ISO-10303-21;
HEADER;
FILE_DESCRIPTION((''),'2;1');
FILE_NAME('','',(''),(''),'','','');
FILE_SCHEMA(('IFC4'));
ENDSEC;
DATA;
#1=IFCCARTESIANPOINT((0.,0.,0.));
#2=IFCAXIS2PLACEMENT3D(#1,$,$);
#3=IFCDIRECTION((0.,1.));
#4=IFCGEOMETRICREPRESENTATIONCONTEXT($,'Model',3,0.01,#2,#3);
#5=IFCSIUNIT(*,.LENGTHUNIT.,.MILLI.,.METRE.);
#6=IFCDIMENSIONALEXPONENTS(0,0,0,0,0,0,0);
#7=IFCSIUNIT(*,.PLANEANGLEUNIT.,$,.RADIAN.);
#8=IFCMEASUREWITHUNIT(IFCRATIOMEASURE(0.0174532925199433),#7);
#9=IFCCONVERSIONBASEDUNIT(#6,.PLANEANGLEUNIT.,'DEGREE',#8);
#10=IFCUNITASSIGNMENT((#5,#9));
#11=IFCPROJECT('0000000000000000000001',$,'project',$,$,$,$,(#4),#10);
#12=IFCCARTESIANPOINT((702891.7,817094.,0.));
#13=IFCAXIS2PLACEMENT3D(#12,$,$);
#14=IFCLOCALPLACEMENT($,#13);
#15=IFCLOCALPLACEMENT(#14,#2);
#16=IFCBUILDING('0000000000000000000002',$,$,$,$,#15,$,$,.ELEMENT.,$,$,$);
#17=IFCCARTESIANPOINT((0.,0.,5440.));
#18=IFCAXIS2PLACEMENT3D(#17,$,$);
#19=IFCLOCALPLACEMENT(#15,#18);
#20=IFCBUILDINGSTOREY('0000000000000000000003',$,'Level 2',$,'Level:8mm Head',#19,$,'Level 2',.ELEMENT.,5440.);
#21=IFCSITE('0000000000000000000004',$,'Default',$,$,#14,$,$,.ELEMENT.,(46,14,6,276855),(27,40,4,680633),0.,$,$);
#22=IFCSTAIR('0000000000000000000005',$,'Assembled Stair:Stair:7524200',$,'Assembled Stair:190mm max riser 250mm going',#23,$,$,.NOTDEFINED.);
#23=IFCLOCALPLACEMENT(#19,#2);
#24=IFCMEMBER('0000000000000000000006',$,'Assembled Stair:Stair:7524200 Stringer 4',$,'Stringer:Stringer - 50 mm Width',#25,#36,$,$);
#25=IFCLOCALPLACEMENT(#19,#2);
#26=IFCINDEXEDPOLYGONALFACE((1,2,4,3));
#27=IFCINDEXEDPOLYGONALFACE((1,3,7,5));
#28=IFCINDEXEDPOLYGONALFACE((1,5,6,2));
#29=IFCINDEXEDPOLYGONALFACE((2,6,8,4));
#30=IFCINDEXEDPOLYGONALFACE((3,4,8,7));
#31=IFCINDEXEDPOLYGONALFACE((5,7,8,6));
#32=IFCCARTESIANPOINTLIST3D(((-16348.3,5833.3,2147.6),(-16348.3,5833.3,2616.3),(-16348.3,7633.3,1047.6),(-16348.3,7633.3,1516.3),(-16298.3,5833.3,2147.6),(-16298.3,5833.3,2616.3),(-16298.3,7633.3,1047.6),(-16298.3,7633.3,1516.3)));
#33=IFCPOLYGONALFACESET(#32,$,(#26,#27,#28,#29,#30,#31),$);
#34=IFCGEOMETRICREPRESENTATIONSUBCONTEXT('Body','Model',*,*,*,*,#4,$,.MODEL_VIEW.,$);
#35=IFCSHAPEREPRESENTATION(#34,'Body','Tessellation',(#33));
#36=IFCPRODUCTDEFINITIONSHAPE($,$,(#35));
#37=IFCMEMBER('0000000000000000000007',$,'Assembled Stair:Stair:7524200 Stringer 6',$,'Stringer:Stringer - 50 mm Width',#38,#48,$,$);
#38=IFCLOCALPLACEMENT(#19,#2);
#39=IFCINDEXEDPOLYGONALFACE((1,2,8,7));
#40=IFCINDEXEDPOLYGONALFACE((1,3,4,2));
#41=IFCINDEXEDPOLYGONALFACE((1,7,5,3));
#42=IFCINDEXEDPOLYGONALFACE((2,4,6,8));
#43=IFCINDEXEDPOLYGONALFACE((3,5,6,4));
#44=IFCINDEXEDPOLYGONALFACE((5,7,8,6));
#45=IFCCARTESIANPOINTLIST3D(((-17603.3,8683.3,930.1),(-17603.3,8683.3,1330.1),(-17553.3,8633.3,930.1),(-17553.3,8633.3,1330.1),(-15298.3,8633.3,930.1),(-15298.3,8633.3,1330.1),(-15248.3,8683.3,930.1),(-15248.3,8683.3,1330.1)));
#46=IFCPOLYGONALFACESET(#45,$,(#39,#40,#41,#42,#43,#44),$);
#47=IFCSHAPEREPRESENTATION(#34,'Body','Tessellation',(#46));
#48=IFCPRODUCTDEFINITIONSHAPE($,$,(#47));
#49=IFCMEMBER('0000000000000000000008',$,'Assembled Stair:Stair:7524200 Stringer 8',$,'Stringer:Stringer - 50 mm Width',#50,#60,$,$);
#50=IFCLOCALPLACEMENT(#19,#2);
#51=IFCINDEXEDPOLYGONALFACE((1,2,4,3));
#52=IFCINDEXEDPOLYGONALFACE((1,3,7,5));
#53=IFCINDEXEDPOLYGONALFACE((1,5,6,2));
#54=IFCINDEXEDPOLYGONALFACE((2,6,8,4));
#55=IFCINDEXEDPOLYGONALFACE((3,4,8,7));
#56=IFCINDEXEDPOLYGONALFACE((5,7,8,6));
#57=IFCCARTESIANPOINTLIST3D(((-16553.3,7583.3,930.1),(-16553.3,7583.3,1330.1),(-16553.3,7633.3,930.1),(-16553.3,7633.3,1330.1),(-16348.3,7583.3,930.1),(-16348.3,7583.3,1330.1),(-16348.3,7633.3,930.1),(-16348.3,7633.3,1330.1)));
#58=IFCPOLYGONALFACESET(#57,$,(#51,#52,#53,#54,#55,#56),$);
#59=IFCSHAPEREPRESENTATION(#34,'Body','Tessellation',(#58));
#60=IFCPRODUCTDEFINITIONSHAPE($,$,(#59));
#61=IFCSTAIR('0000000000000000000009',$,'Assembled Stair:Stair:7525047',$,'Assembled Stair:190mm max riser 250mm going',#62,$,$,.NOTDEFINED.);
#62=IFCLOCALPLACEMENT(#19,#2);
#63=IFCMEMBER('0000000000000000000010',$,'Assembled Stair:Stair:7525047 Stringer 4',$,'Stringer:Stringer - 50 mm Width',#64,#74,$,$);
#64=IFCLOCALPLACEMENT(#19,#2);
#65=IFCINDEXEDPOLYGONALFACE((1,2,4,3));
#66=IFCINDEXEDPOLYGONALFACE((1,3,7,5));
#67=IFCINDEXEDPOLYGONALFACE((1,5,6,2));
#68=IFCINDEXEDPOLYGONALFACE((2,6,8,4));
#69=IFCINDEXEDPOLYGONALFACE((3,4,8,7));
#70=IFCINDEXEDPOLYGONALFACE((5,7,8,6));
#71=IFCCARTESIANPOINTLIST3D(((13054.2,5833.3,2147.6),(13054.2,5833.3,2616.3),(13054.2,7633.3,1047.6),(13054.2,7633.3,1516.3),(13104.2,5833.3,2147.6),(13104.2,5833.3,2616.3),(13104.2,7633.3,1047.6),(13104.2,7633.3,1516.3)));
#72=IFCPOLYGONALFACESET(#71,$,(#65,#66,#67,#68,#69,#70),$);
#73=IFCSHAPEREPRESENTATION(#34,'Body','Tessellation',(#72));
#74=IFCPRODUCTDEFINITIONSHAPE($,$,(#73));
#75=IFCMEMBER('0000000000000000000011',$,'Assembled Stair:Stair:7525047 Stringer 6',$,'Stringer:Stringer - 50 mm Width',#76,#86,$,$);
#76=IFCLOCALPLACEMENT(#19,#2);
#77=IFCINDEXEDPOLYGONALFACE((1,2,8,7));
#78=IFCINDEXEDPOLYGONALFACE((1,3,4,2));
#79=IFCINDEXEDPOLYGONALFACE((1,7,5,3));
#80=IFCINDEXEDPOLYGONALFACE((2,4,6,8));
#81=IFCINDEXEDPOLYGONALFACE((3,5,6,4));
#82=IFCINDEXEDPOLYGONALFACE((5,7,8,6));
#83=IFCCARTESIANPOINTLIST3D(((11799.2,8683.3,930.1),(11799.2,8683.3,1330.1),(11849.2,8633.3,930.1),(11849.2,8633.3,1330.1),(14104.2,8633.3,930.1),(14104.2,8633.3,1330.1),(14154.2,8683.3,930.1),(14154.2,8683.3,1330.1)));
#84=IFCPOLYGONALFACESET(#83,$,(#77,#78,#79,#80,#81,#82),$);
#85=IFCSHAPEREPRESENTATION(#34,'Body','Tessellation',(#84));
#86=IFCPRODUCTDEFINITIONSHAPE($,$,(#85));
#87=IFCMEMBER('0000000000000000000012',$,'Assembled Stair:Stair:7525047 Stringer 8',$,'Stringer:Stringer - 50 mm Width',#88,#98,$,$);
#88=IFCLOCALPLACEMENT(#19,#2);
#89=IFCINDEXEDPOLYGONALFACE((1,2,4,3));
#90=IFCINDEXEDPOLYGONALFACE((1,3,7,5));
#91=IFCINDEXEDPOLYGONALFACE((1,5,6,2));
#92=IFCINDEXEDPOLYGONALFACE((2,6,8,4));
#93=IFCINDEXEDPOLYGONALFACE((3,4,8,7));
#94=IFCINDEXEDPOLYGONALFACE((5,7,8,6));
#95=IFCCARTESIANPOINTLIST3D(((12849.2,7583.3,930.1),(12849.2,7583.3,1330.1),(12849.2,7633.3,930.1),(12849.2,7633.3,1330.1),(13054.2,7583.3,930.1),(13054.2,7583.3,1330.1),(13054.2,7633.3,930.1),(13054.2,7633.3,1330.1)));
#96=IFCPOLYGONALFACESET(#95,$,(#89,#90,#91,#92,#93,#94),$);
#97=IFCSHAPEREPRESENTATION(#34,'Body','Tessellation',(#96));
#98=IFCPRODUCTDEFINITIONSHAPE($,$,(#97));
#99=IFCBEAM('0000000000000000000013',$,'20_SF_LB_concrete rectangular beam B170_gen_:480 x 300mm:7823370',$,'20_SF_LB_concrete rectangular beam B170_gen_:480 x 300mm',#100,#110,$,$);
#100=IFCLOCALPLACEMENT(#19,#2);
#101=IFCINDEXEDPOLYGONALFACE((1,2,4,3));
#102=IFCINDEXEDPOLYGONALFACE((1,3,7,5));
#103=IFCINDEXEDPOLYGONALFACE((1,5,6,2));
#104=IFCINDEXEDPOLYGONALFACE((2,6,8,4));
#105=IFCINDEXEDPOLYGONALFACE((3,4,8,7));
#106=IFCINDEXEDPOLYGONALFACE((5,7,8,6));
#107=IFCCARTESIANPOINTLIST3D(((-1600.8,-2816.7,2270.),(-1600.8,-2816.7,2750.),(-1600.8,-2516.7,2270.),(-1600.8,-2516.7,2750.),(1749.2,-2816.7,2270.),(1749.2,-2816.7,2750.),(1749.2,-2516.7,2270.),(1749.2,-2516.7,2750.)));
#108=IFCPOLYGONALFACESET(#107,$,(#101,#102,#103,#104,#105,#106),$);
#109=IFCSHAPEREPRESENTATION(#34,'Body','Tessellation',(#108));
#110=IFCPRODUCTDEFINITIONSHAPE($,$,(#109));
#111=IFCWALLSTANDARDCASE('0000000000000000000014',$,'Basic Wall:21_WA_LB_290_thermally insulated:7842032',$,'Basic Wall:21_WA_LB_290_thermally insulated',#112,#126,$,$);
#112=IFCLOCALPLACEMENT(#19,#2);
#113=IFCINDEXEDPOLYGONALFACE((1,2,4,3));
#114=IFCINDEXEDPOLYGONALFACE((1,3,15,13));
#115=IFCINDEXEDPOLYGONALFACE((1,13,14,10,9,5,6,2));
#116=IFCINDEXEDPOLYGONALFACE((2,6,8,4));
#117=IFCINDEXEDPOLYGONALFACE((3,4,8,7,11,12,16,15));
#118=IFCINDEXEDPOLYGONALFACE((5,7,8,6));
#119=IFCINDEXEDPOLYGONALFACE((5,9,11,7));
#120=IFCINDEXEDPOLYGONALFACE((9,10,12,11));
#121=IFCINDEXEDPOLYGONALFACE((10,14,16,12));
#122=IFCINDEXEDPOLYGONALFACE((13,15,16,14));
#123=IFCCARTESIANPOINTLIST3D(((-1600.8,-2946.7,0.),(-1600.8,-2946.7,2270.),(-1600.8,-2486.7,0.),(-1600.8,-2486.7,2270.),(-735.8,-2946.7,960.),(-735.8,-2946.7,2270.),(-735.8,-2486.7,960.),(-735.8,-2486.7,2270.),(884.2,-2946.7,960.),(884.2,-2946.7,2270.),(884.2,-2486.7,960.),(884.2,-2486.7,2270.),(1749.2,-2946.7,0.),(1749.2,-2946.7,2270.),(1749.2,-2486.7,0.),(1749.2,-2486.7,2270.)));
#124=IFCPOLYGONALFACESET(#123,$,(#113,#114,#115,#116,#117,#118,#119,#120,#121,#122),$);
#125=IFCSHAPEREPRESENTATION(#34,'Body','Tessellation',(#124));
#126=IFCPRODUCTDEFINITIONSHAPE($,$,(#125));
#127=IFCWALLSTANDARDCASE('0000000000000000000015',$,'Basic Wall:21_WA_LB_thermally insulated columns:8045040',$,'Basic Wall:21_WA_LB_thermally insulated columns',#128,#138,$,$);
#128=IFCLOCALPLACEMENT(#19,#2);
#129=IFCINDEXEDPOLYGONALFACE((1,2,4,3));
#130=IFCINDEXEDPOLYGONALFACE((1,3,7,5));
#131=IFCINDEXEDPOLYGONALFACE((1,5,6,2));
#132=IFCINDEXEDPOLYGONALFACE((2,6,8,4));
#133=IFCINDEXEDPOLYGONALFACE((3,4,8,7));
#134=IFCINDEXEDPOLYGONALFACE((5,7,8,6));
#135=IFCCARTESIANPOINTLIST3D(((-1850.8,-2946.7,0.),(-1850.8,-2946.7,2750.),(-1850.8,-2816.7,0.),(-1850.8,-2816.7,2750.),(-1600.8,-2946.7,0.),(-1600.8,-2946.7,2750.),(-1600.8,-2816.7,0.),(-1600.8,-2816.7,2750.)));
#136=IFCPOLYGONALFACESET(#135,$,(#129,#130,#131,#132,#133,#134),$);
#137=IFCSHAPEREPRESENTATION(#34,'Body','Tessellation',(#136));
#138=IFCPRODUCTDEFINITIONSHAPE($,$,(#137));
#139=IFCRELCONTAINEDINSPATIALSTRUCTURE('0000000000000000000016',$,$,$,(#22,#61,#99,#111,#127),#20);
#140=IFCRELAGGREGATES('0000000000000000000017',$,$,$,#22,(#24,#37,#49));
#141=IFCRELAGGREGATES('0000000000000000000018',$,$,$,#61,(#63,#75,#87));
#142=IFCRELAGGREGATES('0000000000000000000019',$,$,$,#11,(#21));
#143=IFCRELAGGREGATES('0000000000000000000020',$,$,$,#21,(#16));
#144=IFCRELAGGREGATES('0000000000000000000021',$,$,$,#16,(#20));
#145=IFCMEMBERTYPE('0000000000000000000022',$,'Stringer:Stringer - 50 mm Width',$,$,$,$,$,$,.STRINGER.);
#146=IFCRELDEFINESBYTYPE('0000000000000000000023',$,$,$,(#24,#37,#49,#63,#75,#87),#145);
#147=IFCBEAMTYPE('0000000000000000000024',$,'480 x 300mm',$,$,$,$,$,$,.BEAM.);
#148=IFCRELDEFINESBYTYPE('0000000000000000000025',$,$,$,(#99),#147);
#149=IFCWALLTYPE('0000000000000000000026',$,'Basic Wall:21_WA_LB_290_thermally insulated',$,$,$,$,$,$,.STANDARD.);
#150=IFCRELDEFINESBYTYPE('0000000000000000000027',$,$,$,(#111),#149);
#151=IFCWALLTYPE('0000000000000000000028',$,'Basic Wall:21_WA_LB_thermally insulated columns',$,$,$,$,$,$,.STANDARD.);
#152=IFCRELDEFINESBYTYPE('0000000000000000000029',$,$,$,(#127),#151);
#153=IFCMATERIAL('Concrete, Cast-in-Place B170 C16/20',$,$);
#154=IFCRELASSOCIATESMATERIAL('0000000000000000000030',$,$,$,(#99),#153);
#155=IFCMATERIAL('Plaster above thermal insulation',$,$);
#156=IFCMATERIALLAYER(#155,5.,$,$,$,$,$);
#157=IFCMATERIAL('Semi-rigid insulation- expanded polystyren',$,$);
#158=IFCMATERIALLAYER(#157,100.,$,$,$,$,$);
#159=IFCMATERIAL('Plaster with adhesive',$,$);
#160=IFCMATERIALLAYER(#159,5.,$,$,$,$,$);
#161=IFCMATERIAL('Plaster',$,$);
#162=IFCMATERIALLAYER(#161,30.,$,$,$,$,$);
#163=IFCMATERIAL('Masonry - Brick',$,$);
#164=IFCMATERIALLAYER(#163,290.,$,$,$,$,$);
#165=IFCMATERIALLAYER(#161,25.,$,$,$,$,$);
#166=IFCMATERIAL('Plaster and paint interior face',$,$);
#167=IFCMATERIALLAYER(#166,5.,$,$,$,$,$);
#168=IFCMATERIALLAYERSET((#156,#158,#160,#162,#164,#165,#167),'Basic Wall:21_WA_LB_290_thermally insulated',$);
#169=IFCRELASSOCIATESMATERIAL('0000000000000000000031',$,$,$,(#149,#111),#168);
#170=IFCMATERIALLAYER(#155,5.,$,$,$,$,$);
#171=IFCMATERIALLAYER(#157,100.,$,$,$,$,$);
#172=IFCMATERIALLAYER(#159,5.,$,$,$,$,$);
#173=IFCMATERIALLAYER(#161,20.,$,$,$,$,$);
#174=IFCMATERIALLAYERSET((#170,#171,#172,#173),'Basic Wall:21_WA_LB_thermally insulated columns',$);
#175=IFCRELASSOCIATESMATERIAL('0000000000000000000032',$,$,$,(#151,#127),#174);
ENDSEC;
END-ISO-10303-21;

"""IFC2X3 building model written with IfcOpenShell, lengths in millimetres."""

from ifc_helpers import new_model, entity, si_unit, converted_unit, direction, frame, frame_2d, origin, origin_2d_with_axis, place, context, subcontext, project, spatial, polyline, rectangle, outline, extrude, clip, halfspace, material, layer, layer_set, layer_usage, type_object, element, aggregate, save


model = new_model("IFC2X3")

# Units and contexts
model_context = context("Model", 3, precision=0.01, world=origin(), true_north=direction((0.0, 1.0)))
body_context = subcontext(model_context, "Body", "Model", "MODEL_VIEW")
ifc_project = project(units=[si_unit("LENGTHUNIT", "METRE", prefix="MILLI"), converted_unit("PLANEANGLEUNIT", "DEGREE", entity("IfcRatioMeasure", 0.0174532925199433), si_unit("PLANEANGLEUNIT", "RADIAN"), dimensions=[0, 0, 0, 0, 0, 0, 0])], contexts=[model_context])

# Site, building, storey
site_placement = place(None, frame((702891.7, 817094.0, 0.0)))
site = spatial("IfcSite", under=ifc_project, at=site_placement, Name="Default", CompositionType="ELEMENT", RefLatitude=(46, 14, 6, 276855), RefLongitude=(27, 40, 4, 680633), RefElevation=0.0)
building_placement = place(site_placement, origin())
building = spatial("IfcBuilding", under=site, at=building_placement, CompositionType="ELEMENT")
storey_placement = place(building_placement, frame((0.0, 0.0, 5440.0)))
storey = spatial("IfcBuildingStorey", under=building, at=storey_placement, Name="Level 2", ObjectType="Level:8mm Head", LongName="Level 2", CompositionType="ELEMENT", Elevation=5440.0)

# Stairs, members
stair_1_placement = place(storey_placement, origin())
stair_1 = element("IfcStair", 1, at=stair_1_placement, inside=storey, Name="Assembled Stair:Stair:7524200", ObjectType="Assembled Stair:190mm max riser 250mm going", ShapeType="NOTDEFINED")
member_type = type_object("IfcMemberType", Name="Stringer:Stringer - 50 mm Width", PredefinedType="STRINGER")
member_1_placement = place(stair_1_placement, origin())
member_1 = element("IfcMember", 2, at=member_1_placement, type_object=member_type, Name="Assembled Stair:Stair:7524200 Stringer 4", ObjectType="Stringer:Stringer - 50 mm Width", context=body_context, shape_type="SweptSolid", body=[
    extrude(outline(polyline([(-932.5, -200.0), (1177.0, -200.0), (932.5, 200.0), (-1177.0, 200.0), (-932.5, -200.0)])), frame((-16348.3, 6733.3, 1831.9), z_axis=(1.0, 0.0, 0.0), x_axis=(0.0, -0.853282, 0.52145)), (0.0, 0.0, 1.0), 50.0),
])
member_2_placement = place(stair_1_placement, origin())
member_2 = element("IfcMember", 3, at=member_2_placement, type_object=member_type, Name="Assembled Stair:Stair:7524200 Stringer 6", ObjectType="Stringer:Stringer - 50 mm Width", context=body_context, shape_type="SweptSolid", body=[
    extrude(outline(polyline([(-1177.5, -25.0), (1177.5, -25.0), (1127.5, 25.0), (-1127.5, 25.0), (-1177.5, -25.0)])), frame((-16425.8, 8658.3, 930.1), z_axis=(0.0, 0.0, 1.0), x_axis=(-1.0, 0.0, 0.0)), (0.0, 0.0, 1.0), 400.0),
])
member_3_placement = place(stair_1_placement, origin())
member_3 = element("IfcMember", 4, at=member_3_placement, type_object=member_type, Name="Assembled Stair:Stair:7524200 Stringer 8", ObjectType="Stringer:Stringer - 50 mm Width", context=body_context, shape_type="SweptSolid", body=[
    extrude(rectangle(XDim=205.0, YDim=50.0, at=origin_2d_with_axis()), frame((-16450.8, 7608.3, 930.1)), (0.0, 0.0, 1.0), 400.0),
])
stair_2_placement = place(storey_placement, origin())
stair_2 = element("IfcStair", 5, at=stair_2_placement, inside=storey, Name="Assembled Stair:Stair:7525047", ObjectType="Assembled Stair:190mm max riser 250mm going", ShapeType="NOTDEFINED")
member_4_placement = place(stair_2_placement, origin())
member_4 = element("IfcMember", 6, at=member_4_placement, type_object=member_type, Name="Assembled Stair:Stair:7525047 Stringer 4", ObjectType="Stringer:Stringer - 50 mm Width", context=body_context, shape_type="SweptSolid", body=[
    extrude(outline(polyline([(-932.5, -200.0), (1177.0, -200.0), (932.5, 200.0), (-1177.0, 200.0), (-932.5, -200.0)])), frame((13054.2, 6733.3, 1831.9), z_axis=(1.0, 0.0, 0.0), x_axis=(0.0, -0.853282, 0.52145)), (0.0, 0.0, 1.0), 50.0),
])
member_5_placement = place(stair_2_placement, origin())
member_5 = element("IfcMember", 7, at=member_5_placement, type_object=member_type, Name="Assembled Stair:Stair:7525047 Stringer 6", ObjectType="Stringer:Stringer - 50 mm Width", context=body_context, shape_type="SweptSolid", body=[
    extrude(outline(polyline([(-1177.5, -25.0), (1177.5, -25.0), (1127.5, 25.0), (-1127.5, 25.0), (-1177.5, -25.0)])), frame((12976.7, 8658.3, 930.1), z_axis=(0.0, 0.0, 1.0), x_axis=(-1.0, 0.0, 0.0)), (0.0, 0.0, 1.0), 400.0),
])
member_6_placement = place(stair_2_placement, origin())
member_6 = element("IfcMember", 8, at=member_6_placement, type_object=member_type, Name="Assembled Stair:Stair:7525047 Stringer 8", ObjectType="Stringer:Stringer - 50 mm Width", context=body_context, shape_type="SweptSolid", body=[
    extrude(rectangle(XDim=205.0, YDim=50.0, at=frame_2d((0.0, 0.0), x_axis=(1.0, 0.0))), frame((12951.7, 7608.3, 930.1)), (0.0, 0.0, 1.0), 400.0),
])

# Beam
ifc_material_1 = material(Name="Concrete, Cast-in-Place B170 C16/20")
beam_type = type_object("IfcBeamType", Name="480 x 300mm", PredefinedType="BEAM")
beam_placement = place(storey_placement, frame((-1600.8, -2666.7, 0.0)))
element("IfcBeam", 9, at=beam_placement, inside=storey, type_object=beam_type, material=ifc_material_1, Name="20_SF_LB_concrete rectangular beam B170_gen_:480 x 300mm:7823370", ObjectType="20_SF_LB_concrete rectangular beam B170_gen_:480 x 300mm", context=body_context, shape_type="SweptSolid", body=[
    extrude(rectangle(XDim=480.0, YDim=300.0, at=frame_2d((0.0, 0.0), x_axis=(1.0, 0.0))), frame((0.0, 0.0, 2510.0), z_axis=(1.0, 0.0, 0.0), x_axis=(0.0, 0.0, -1.0)), (0.0, 0.0, 1.0), 3350.0),
])

# Wall, opening
ifc_material_2 = material(Name="Plaster above thermal insulation")
ifc_layer_1 = layer(ifc_material_2, 5.0)
ifc_material_3 = material(Name="Semi-rigid insulation- expanded polystyren")
ifc_layer_2 = layer(ifc_material_3, 100.0)
ifc_material_4 = material(Name="Plaster with adhesive")
ifc_layer_3 = layer(ifc_material_4, 5.0)
ifc_material_5 = material(Name="Plaster")
ifc_layer_4 = layer(ifc_material_5, 30.0)
ifc_material_6 = material(Name="Masonry - Brick")
ifc_layer_5 = layer(ifc_material_6, 290.0)
ifc_layer_6 = layer(ifc_material_5, 25.0)
ifc_material_7 = material(Name="Plaster and paint interior face")
ifc_layer_7 = layer(ifc_material_7, 5.0)
ifc_layer_set_1 = layer_set([ifc_layer_1, ifc_layer_2, ifc_layer_3, ifc_layer_4, ifc_layer_5, ifc_layer_6, ifc_layer_7], Name="Basic Wall:21_WA_LB_290_thermally insulated")
ifc_layer_usage_1 = layer_usage(ifc_layer_set_1, "AXIS2", "POSITIVE", -230.0)
wall_type_1 = type_object("IfcWallType", Name="Basic Wall:21_WA_LB_290_thermally insulated", PredefinedType="STANDARD", material=ifc_layer_set_1)
wall_1_placement = place(storey_placement, frame((-1600.8, -2716.7, 0.0)))
wall_1 = element("IfcWallStandardCase", 10, at=wall_1_placement, inside=storey, type_object=wall_type_1, material=ifc_layer_usage_1, Name="Basic Wall:21_WA_LB_290_thermally insulated:7842032", ObjectType="Basic Wall:21_WA_LB_290_thermally insulated", context=body_context, shape_type="SweptSolid", body=[
    extrude(rectangle(XDim=3350.0, YDim=460.0, at=frame_2d((1675.0, 0.0), x_axis=(-1.0, 0.0))), origin(), (0.0, 0.0, 1.0), 2270.0),
])
opening_placement = place(wall_1_placement, frame((2485.0, 230.0, 960.0)))
element("IfcOpeningElement", 11, at=opening_placement, cuts=wall_1, ObjectType="Opening", context=body_context, shape_type="SweptSolid", body=[
    extrude(rectangle(XDim=1320.0, YDim=1620.0, at=frame_2d((660.0, 810.0), x_axis=(1.0, 0.0))), frame((0.0, 0.0, 0.0), z_axis=(0.0, -1.0, 0.0), x_axis=(0.0, 0.0, 1.0)), (0.0, 0.0, 1.0), 460.0),
])

# Wall
ifc_layer_8 = layer(ifc_material_2, 5.0)
ifc_layer_9 = layer(ifc_material_3, 100.0)
ifc_layer_10 = layer(ifc_material_4, 5.0)
ifc_layer_11 = layer(ifc_material_5, 20.0)
ifc_layer_set_2 = layer_set([ifc_layer_8, ifc_layer_9, ifc_layer_10, ifc_layer_11], Name="Basic Wall:21_WA_LB_thermally insulated columns")
ifc_layer_usage_2 = layer_usage(ifc_layer_set_2, "AXIS2", "NEGATIVE", 65.0)
wall_type_2 = type_object("IfcWallType", Name="Basic Wall:21_WA_LB_thermally insulated columns", PredefinedType="STANDARD", material=ifc_layer_set_2)
wall_2_placement = place(storey_placement, frame((-1600.8, -2881.7, 0.0), z_axis=(0.0, 0.0, 1.0), x_axis=(-1.0, 0.0, 0.0)))
element("IfcWallStandardCase", 12, at=wall_2_placement, inside=storey, type_object=wall_type_2, material=ifc_layer_usage_2, Name="Basic Wall:21_WA_LB_thermally insulated columns:8045040", ObjectType="Basic Wall:21_WA_LB_thermally insulated columns", context=body_context, shape_type="Clipping", body=[
    clip(extrude(rectangle(XDim=250.0, YDim=130.0, at=frame_2d((125.0, 0.0), x_axis=(-1.0, 0.0))), origin(), (0.0, 0.0, 1.0), 2750.0), halfspace(frame((0.0, 0.0, -5500.0)), True)),
])

aggregate(stair_1, [member_1, member_2, member_3])
aggregate(stair_2, [member_4, member_5, member_6])

save(model, "model.ifc")
